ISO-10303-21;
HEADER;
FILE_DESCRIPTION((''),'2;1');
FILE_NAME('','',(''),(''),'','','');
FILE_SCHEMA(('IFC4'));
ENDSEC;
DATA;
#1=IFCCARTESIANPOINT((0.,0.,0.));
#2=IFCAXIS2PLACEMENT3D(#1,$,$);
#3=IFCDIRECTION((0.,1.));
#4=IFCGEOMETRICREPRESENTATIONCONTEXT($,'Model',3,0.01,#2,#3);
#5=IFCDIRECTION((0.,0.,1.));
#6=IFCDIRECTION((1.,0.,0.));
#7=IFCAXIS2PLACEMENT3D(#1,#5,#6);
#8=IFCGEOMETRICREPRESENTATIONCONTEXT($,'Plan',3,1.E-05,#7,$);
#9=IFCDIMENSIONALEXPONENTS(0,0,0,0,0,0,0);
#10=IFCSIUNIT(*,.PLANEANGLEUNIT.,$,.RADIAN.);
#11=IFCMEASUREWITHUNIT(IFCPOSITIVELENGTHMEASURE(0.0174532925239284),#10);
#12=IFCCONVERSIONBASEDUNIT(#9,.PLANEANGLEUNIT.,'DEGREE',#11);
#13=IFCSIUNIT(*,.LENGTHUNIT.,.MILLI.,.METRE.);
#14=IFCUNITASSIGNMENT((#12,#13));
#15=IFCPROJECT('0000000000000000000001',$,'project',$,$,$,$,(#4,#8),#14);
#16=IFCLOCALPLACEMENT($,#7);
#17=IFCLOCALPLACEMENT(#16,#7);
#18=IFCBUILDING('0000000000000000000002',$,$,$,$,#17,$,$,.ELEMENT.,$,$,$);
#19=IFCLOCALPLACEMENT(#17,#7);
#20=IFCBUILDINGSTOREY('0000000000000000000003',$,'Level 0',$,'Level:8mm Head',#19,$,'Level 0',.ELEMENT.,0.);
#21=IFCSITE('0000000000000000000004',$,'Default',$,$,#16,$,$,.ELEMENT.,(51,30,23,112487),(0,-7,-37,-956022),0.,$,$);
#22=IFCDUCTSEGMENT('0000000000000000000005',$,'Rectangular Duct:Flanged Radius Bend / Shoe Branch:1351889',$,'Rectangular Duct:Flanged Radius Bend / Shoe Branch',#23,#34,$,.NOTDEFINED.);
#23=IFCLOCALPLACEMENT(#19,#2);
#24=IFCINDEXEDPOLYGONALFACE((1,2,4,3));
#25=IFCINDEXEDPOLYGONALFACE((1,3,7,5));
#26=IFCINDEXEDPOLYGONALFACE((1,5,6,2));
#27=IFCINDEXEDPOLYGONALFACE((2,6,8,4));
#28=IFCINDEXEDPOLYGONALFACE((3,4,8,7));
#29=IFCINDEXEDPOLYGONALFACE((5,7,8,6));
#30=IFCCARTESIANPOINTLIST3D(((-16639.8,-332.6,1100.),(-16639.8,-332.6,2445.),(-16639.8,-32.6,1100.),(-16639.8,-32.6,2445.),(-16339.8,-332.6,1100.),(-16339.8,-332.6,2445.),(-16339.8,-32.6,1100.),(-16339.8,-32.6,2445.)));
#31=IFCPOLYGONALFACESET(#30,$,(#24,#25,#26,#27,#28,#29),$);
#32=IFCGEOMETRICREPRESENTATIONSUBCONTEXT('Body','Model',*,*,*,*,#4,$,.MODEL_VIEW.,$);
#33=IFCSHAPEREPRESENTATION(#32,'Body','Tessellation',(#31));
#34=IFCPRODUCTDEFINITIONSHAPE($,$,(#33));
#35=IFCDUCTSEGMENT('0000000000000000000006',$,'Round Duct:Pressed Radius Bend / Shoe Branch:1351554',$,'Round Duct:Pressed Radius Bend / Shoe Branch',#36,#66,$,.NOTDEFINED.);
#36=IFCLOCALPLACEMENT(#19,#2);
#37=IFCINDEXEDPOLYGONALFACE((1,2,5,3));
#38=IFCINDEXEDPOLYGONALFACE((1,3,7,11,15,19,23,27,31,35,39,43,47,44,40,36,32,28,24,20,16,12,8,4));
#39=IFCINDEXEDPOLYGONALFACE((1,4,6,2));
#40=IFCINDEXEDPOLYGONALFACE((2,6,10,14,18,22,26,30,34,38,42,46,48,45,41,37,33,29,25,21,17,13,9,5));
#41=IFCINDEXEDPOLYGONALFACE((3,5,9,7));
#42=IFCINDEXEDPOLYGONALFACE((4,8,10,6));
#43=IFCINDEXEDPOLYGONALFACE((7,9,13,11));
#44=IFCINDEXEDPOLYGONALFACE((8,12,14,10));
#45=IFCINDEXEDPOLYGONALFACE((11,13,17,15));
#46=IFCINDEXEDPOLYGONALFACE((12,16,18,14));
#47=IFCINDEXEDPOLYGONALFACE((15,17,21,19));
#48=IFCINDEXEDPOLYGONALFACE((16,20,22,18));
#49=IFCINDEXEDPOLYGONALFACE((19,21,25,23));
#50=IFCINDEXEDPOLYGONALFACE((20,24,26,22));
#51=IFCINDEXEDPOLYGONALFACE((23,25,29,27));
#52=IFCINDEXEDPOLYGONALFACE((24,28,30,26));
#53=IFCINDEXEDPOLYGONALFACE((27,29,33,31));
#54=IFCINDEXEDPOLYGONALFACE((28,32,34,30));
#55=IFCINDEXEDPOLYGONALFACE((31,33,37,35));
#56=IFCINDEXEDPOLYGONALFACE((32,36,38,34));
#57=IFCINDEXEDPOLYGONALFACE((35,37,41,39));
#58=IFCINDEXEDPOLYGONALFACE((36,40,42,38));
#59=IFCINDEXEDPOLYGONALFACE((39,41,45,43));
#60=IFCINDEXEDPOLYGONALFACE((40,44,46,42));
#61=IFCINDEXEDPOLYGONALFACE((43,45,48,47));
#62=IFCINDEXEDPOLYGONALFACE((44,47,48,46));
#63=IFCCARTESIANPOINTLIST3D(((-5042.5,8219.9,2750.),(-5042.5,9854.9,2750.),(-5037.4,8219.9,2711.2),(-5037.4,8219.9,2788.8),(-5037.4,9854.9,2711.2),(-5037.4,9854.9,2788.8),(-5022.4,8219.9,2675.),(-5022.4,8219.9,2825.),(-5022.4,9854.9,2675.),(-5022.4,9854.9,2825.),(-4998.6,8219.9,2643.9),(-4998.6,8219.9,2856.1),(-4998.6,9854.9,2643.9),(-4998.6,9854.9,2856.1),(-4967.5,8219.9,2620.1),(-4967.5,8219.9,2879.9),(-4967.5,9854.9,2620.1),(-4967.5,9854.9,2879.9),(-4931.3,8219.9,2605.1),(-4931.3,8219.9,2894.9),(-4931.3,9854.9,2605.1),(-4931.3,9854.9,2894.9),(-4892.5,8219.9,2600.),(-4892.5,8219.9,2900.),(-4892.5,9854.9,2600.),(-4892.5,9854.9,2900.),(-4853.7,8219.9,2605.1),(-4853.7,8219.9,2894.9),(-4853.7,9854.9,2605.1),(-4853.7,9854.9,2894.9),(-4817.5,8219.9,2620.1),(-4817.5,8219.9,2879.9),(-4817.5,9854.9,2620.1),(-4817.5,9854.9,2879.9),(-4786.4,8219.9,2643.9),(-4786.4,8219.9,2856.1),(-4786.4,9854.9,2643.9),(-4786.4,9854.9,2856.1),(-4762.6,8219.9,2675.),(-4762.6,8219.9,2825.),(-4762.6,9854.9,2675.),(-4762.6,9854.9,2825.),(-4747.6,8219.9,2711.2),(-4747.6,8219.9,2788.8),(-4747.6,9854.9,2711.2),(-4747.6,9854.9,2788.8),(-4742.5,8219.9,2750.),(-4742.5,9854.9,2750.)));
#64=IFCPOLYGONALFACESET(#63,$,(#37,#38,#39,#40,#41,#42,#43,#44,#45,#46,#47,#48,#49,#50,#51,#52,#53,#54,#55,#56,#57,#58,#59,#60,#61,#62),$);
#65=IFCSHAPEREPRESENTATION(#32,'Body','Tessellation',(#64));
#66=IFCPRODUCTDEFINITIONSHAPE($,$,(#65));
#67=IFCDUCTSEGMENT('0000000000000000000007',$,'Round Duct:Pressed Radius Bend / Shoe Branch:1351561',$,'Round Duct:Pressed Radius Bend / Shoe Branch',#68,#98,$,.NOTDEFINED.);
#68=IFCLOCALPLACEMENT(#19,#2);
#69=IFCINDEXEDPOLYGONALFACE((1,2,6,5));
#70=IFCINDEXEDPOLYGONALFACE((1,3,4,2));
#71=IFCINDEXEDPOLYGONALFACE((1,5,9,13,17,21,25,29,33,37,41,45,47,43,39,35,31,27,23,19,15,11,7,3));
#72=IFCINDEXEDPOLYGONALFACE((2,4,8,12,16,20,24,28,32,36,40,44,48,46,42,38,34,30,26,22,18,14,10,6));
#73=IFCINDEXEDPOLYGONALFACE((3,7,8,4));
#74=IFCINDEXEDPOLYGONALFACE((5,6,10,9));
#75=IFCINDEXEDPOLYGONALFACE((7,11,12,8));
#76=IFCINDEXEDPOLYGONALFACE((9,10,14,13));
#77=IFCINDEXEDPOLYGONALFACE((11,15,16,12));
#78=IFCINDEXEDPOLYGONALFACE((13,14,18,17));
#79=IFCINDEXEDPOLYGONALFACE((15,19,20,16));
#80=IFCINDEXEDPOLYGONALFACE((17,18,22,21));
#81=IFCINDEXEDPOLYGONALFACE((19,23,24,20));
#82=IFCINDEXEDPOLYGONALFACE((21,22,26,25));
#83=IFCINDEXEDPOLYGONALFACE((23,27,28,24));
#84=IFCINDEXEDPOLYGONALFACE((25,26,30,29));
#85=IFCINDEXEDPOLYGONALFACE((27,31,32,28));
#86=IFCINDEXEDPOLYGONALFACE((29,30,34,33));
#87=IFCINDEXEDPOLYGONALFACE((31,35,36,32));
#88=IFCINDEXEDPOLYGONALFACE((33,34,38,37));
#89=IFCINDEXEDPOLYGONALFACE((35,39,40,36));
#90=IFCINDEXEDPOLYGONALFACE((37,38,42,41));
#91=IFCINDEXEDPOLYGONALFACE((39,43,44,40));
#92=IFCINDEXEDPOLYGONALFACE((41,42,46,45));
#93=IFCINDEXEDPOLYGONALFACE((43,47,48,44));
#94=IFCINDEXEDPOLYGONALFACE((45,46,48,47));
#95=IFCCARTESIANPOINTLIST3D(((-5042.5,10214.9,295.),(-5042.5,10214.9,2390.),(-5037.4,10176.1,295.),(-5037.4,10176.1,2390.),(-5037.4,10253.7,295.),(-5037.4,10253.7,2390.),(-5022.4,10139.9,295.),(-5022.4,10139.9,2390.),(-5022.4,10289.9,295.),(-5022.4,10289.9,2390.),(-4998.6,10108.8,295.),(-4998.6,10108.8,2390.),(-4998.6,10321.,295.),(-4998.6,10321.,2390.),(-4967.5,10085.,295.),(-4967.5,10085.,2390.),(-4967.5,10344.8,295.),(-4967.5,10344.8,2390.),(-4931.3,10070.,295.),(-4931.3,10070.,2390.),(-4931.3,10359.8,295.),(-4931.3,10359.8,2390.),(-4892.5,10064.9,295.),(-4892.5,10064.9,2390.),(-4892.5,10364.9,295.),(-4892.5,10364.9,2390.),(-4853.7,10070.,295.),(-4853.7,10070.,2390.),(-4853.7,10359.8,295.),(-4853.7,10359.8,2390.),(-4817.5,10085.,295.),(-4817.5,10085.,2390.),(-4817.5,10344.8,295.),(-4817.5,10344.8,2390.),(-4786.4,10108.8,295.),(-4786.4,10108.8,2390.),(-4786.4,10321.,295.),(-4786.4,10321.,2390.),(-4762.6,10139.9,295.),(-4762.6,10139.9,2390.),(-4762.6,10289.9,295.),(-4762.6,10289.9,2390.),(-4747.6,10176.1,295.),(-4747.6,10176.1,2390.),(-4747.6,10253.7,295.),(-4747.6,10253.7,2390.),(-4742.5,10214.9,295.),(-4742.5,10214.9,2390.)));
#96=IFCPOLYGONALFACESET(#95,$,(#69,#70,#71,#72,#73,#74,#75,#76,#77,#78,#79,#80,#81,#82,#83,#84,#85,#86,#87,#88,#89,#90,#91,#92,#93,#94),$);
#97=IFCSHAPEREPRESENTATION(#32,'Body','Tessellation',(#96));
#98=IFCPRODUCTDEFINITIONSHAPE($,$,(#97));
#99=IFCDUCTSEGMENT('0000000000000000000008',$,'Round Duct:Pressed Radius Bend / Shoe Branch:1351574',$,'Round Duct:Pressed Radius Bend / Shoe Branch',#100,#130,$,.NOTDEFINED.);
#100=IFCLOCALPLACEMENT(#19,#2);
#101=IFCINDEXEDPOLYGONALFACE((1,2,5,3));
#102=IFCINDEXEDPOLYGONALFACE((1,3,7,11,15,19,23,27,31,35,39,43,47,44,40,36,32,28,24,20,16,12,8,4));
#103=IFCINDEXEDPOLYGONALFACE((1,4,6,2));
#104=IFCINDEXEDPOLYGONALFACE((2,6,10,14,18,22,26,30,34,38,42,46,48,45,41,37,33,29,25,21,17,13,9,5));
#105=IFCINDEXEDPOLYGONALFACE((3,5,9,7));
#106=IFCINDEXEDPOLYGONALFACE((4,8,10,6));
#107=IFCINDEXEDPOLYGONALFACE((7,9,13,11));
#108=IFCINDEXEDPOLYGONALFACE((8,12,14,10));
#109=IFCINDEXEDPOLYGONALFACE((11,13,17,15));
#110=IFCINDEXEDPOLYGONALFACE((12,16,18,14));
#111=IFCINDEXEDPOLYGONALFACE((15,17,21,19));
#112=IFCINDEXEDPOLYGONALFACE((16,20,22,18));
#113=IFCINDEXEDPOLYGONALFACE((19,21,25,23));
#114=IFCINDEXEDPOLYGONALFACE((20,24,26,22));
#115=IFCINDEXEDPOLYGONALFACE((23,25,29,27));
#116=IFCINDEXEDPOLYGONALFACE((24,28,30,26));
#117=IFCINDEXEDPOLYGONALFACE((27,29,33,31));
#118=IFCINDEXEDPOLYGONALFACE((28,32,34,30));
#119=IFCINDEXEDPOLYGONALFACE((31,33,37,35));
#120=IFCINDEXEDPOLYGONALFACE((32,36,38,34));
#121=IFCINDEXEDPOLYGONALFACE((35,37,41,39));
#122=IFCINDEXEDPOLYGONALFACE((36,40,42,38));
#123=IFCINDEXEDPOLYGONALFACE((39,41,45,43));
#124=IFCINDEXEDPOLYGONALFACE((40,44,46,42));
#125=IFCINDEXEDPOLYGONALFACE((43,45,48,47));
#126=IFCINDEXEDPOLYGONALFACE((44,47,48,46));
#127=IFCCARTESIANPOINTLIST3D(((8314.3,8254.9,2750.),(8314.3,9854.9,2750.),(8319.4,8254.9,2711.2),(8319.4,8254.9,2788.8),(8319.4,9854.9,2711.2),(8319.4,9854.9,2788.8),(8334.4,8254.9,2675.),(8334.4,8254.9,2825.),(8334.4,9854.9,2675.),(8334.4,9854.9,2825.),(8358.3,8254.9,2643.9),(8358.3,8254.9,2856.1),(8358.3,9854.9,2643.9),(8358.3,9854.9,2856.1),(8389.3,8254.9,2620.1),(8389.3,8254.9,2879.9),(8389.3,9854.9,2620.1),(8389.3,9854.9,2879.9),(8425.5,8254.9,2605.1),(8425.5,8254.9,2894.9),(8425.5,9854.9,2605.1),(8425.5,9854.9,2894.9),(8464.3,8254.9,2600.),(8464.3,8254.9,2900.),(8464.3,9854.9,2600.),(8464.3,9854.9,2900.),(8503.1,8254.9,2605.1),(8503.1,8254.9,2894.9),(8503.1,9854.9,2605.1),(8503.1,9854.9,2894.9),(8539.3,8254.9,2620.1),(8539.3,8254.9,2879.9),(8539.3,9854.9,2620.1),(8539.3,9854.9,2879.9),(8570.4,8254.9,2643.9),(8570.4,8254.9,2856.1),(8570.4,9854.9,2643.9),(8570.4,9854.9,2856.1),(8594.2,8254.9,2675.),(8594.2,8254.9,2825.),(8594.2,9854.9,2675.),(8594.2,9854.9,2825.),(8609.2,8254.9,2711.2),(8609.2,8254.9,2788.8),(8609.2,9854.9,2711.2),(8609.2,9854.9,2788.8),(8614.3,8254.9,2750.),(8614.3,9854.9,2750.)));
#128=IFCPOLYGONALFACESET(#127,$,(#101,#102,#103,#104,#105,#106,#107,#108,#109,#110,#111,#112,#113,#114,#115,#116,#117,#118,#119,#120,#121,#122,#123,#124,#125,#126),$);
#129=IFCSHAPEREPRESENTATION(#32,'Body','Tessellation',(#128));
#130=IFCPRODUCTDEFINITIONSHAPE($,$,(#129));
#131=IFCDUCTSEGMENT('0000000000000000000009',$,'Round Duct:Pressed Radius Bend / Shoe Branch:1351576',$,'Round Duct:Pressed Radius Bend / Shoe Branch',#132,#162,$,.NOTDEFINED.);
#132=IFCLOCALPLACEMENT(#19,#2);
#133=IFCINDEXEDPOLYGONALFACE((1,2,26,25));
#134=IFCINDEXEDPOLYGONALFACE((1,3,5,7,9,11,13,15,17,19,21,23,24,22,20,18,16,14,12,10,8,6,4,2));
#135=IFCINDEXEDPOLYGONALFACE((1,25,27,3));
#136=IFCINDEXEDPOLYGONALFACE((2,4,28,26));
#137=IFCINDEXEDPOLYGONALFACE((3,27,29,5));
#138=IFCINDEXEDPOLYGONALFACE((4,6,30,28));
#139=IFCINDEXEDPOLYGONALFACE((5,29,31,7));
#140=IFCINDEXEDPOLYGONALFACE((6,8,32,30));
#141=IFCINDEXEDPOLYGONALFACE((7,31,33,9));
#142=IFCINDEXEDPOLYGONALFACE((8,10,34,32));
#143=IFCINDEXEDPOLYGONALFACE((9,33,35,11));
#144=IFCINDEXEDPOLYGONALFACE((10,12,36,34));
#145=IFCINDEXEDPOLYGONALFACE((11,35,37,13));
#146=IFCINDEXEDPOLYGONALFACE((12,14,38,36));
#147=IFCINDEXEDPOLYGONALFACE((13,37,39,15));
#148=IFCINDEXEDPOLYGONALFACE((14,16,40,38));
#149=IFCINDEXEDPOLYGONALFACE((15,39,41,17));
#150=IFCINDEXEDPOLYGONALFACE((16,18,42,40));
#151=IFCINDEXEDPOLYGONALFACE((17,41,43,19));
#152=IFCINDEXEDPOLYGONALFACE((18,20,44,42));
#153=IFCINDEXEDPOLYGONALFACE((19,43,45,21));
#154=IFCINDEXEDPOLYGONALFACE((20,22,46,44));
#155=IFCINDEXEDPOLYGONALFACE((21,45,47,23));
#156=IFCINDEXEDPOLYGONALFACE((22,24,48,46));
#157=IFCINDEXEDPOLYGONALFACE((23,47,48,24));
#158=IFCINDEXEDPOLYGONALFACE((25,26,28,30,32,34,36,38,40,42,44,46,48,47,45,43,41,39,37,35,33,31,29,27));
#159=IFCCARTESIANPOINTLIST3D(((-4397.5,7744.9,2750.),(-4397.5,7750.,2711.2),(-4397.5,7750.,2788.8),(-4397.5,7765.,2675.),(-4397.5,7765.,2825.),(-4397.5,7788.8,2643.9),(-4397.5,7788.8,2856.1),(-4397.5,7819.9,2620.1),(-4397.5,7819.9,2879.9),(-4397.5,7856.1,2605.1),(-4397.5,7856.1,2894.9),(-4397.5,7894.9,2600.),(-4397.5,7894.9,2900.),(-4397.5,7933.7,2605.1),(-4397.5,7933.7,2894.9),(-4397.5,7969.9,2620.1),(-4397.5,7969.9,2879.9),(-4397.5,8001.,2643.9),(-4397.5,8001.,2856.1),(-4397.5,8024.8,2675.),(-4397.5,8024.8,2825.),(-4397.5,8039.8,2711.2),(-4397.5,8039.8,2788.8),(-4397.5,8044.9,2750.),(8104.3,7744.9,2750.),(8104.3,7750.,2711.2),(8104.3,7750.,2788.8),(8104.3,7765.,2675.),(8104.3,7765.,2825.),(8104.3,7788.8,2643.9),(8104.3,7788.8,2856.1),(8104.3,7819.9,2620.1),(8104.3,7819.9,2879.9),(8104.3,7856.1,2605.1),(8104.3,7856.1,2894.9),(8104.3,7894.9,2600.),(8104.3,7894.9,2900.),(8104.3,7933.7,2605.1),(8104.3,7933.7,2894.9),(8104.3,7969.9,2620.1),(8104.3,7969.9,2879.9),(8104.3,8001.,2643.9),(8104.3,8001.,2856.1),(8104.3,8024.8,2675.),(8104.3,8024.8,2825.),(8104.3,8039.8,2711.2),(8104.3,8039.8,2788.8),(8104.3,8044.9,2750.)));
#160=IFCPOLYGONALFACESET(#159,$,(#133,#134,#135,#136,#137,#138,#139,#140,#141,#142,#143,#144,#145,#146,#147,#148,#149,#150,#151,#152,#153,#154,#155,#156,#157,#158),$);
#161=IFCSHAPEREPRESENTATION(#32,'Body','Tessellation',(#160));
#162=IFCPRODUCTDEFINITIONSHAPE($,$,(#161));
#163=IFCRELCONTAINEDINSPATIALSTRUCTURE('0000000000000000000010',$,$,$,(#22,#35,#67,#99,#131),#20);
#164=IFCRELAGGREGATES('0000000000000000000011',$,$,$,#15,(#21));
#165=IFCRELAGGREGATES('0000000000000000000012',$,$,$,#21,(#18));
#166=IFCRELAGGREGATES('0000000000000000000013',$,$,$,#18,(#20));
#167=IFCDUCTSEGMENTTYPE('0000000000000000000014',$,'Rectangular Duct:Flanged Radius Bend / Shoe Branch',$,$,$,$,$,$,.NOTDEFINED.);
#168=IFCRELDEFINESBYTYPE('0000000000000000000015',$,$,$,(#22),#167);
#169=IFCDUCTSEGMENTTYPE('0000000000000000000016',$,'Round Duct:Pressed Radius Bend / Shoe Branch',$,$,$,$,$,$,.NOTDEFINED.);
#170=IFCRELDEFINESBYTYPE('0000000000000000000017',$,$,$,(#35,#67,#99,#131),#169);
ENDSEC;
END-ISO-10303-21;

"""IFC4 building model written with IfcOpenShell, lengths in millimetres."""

from ifc_helpers import new_model, entity, si_unit, converted_unit, direction, frame, origin, origin_with_axes, place, context, subcontext, project, spatial, arc, indexed_curve, outline, extrude, type_object, element, save


model = new_model("IFC4")

# Units and contexts
model_context = context("Model", 3, precision=0.01, world=origin(), true_north=direction((0.0, 1.0)))
plan_context = context("Plan", 3, precision=1e-05, world=origin_with_axes())
body_context = subcontext(model_context, "Body", "Model", "MODEL_VIEW")
ifc_project = project(units=[converted_unit("PLANEANGLEUNIT", "DEGREE", entity("IfcPositiveLengthMeasure", 0.0174532925239284), si_unit("PLANEANGLEUNIT", "RADIAN"), dimensions=[0, 0, 0, 0, 0, 0, 0]), si_unit("LENGTHUNIT", "METRE", prefix="MILLI")], contexts=[model_context, plan_context])

# Site, building, storey
site_placement = place(None, origin_with_axes())
site = spatial("IfcSite", under=ifc_project, at=site_placement, Name="Default", CompositionType="ELEMENT", RefLatitude=(51, 30, 23, 112487), RefLongitude=(0, -7, -37, -956022), RefElevation=0.0)
building_placement = place(site_placement, origin_with_axes())
building = spatial("IfcBuilding", under=site, at=building_placement, CompositionType="ELEMENT")
storey_placement = place(building_placement, origin_with_axes())
storey = spatial("IfcBuildingStorey", under=building, at=storey_placement, Name="Level 0", ObjectType="Level:8mm Head", LongName="Level 0", CompositionType="ELEMENT", Elevation=0.0)

# Duct segments
duct_segment_type_1 = type_object("IfcDuctSegmentType", Name="Rectangular Duct:Flanged Radius Bend / Shoe Branch", PredefinedType="NOTDEFINED")
duct_segment_1_placement = place(storey_placement, origin_with_axes())
element("IfcDuctSegment", 1, at=duct_segment_1_placement, inside=storey, type_object=duct_segment_type_1, Name="Rectangular Duct:Flanged Radius Bend / Shoe Branch:1351889", ObjectType="Rectangular Duct:Flanged Radius Bend / Shoe Branch", PredefinedType="NOTDEFINED", context=body_context, shape_type="SweptSolid", body=[
    extrude(outline(indexed_curve([(-150.0, -150.0), (150.0, -150.0), (150.0, 150.0), (-150.0, 150.0), (-150.0, -150.0)], self_intersect=False)), frame((-16489.8, -182.6, 1100.0), z_axis=(0.0, 0.0, 1.0), x_axis=(0.0, 1.0, 0.0)), (0.0, 0.0, 1.0), 1345.0),
])
duct_segment_type_2 = type_object("IfcDuctSegmentType", Name="Round Duct:Pressed Radius Bend / Shoe Branch", PredefinedType="NOTDEFINED")
duct_segment_2_placement = place(storey_placement, origin_with_axes())
element("IfcDuctSegment", 2, at=duct_segment_2_placement, inside=storey, type_object=duct_segment_type_2, Name="Round Duct:Pressed Radius Bend / Shoe Branch:1351554", ObjectType="Round Duct:Pressed Radius Bend / Shoe Branch", PredefinedType="NOTDEFINED", context=body_context, shape_type="SweptSolid", body=[
    extrude(outline(indexed_curve([(150.0, 0.0), (106.1, 106.1), (0.0, 150.0), (-106.1, 106.1), (-150.0, 0.0), (-106.1, -106.1), (0.0, -150.0), (106.1, -106.1)], segments=[arc(1, 2, 3), arc(3, 4, 5), arc(5, 6, 7), arc(7, 8, 1)], self_intersect=False)), frame((-4892.5, 8219.9, 2750.0), z_axis=(0.0, 1.0, 0.0), x_axis=(1.0, 0.0, 0.0)), (0.0, 0.0, 1.0), 1635.0),
])
duct_segment_3_placement = place(storey_placement, origin_with_axes())
element("IfcDuctSegment", 3, at=duct_segment_3_placement, inside=storey, type_object=duct_segment_type_2, Name="Round Duct:Pressed Radius Bend / Shoe Branch:1351561", ObjectType="Round Duct:Pressed Radius Bend / Shoe Branch", PredefinedType="NOTDEFINED", context=body_context, shape_type="SweptSolid", body=[
    extrude(outline(indexed_curve([(150.0, 0.0), (106.1, 106.1), (0.0, 150.0), (-106.1, 106.1), (-150.0, 0.0), (-106.1, -106.1), (0.0, -150.0), (106.1, -106.1)], segments=[arc(1, 2, 3), arc(3, 4, 5), arc(5, 6, 7), arc(7, 8, 1)], self_intersect=False)), frame((-4892.5, 10214.9, 295.0)), (0.0, 0.0, 1.0), 2095.0),
])
duct_segment_4_placement = place(storey_placement, origin_with_axes())
element("IfcDuctSegment", 4, at=duct_segment_4_placement, inside=storey, type_object=duct_segment_type_2, Name="Round Duct:Pressed Radius Bend / Shoe Branch:1351574", ObjectType="Round Duct:Pressed Radius Bend / Shoe Branch", PredefinedType="NOTDEFINED", context=body_context, shape_type="SweptSolid", body=[
    extrude(outline(indexed_curve([(150.0, 0.0), (106.1, 106.1), (0.0, 150.0), (-106.1, 106.1), (-150.0, 0.0), (-106.1, -106.1), (0.0, -150.0), (106.1, -106.1)], segments=[arc(1, 2, 3), arc(3, 4, 5), arc(5, 6, 7), arc(7, 8, 1)], self_intersect=False)), frame((8464.3, 8254.9, 2750.0), z_axis=(0.0, 1.0, 0.0), x_axis=(-1.0, 0.0, 0.0)), (0.0, 0.0, 1.0), 1600.0),
])
duct_segment_5_placement = place(storey_placement, origin_with_axes())
element("IfcDuctSegment", 5, at=duct_segment_5_placement, inside=storey, type_object=duct_segment_type_2, Name="Round Duct:Pressed Radius Bend / Shoe Branch:1351576", ObjectType="Round Duct:Pressed Radius Bend / Shoe Branch", PredefinedType="NOTDEFINED", context=body_context, shape_type="SweptSolid", body=[
    extrude(outline(indexed_curve([(150.0, 0.0), (106.1, 106.1), (0.0, 150.0), (-106.1, 106.1), (-150.0, 0.0), (-106.1, -106.1), (0.0, -150.0), (106.1, -106.1)], segments=[arc(1, 2, 3), arc(3, 4, 5), arc(5, 6, 7), arc(7, 8, 1)], self_intersect=False)), frame((-4397.5, 7894.9, 2750.0), z_axis=(1.0, 0.0, 0.0), x_axis=(0.0, 1.0, 0.0)), (0.0, 0.0, 1.0), 12501.8),
])

save(model, "model.ifc")
